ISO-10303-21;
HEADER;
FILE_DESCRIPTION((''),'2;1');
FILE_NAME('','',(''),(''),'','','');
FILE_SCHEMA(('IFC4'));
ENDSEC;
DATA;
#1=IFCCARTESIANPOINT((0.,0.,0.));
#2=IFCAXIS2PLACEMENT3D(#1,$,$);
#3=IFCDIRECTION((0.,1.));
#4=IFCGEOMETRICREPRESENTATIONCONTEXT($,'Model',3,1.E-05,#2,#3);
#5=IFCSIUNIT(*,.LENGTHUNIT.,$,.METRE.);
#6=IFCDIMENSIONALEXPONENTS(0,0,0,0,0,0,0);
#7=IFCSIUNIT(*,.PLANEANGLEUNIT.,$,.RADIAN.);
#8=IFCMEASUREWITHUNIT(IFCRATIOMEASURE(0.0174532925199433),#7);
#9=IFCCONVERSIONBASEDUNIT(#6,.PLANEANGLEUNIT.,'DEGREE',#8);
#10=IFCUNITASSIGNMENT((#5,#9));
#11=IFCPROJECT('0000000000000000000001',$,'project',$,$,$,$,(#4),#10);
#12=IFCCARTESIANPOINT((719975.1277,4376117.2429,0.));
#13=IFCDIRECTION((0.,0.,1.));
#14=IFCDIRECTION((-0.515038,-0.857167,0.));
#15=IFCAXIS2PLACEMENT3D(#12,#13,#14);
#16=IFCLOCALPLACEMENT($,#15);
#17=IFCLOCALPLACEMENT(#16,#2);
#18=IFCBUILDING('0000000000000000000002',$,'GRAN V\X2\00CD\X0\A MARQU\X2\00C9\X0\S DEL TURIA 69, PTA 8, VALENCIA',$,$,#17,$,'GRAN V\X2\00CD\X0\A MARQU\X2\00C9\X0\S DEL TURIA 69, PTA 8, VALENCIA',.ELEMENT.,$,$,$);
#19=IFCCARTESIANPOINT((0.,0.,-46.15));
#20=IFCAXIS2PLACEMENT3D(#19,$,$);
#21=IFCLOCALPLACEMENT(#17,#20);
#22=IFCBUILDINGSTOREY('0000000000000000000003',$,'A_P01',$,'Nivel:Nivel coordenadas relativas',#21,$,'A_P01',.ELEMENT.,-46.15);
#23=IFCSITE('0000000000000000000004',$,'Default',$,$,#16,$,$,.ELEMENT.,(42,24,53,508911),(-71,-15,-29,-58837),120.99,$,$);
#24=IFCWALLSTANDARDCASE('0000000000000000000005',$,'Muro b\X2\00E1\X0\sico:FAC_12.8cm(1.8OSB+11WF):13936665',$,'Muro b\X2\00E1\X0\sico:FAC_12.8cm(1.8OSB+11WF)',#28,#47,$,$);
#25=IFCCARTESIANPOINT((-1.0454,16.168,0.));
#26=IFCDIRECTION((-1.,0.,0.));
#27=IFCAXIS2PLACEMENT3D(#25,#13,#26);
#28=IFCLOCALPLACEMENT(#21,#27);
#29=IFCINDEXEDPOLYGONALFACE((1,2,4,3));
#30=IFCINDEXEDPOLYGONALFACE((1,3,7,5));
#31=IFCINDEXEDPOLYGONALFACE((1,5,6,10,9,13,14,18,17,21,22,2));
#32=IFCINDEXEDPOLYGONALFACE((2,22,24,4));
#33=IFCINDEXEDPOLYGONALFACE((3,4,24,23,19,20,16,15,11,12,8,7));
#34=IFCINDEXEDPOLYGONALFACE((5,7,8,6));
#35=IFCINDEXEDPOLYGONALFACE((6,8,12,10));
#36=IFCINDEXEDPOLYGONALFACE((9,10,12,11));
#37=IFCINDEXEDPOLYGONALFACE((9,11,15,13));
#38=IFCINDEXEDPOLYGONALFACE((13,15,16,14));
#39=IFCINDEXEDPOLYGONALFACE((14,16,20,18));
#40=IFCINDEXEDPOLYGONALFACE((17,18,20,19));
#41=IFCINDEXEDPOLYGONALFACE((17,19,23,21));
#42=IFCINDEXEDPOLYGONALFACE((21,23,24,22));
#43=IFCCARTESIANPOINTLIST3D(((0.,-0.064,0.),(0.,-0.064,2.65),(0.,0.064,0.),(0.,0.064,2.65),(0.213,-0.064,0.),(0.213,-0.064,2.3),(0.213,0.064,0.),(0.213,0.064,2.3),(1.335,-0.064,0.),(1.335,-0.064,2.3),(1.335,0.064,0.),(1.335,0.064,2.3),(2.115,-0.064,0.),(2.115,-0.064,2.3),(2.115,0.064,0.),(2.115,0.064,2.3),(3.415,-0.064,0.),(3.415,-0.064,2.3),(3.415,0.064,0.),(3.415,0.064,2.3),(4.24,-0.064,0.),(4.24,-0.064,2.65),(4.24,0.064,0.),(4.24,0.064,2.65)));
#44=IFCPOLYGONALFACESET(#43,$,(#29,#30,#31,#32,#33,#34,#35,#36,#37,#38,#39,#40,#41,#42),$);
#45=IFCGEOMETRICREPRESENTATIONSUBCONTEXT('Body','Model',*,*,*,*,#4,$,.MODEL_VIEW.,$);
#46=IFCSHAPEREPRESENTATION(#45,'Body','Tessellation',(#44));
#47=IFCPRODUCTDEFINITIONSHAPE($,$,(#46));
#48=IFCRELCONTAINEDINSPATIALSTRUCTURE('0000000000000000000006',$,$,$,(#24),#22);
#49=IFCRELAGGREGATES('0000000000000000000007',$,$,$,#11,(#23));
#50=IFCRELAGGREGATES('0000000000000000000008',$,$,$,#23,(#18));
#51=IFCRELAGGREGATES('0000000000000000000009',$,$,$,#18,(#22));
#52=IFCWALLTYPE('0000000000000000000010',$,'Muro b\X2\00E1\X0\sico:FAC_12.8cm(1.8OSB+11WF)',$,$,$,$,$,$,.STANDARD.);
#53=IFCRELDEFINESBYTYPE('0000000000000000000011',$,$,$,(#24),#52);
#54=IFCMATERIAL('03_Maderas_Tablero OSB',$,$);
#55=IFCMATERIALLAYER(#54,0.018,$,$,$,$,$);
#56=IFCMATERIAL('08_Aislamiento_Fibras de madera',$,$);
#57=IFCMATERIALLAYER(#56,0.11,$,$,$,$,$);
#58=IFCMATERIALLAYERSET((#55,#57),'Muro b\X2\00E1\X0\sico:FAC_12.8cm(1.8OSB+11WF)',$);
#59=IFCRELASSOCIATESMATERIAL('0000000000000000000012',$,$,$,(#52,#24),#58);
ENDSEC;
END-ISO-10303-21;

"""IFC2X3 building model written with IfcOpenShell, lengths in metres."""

from ifc_helpers import new_model, entity, si_unit, converted_unit, direction, frame, frame_2d, origin, place, context, subcontext, project, spatial, rectangle, extrude, material, layer, layer_set, layer_usage, type_object, element, save


model = new_model("IFC2X3")

# Units and contexts
model_context = context("Model", 3, precision=1e-05, world=origin(), true_north=direction((0.0, 1.0)))
body_context = subcontext(model_context, "Body", "Model", "MODEL_VIEW")
ifc_project = project(units=[si_unit("LENGTHUNIT", "METRE"), converted_unit("PLANEANGLEUNIT", "DEGREE", entity("IfcRatioMeasure", 0.0174532925199433), si_unit("PLANEANGLEUNIT", "RADIAN"), dimensions=[0, 0, 0, 0, 0, 0, 0])], contexts=[model_context])

# Site, building, storey
site_placement = place(None, frame((719975.1277, 4376117.2429, 0.0), z_axis=(0.0, 0.0, 1.0), x_axis=(-0.515038, -0.857167, 0.0)))
site = spatial("IfcSite", under=ifc_project, at=site_placement, Name="Default", CompositionType="ELEMENT", RefLatitude=(42, 24, 53, 508911), RefLongitude=(-71, -15, -29, -58837), RefElevation=120.99)
building_placement = place(site_placement, origin())
building = spatial("IfcBuilding", under=site, at=building_placement, Name="GRAN VÍA MARQUÉS DEL TURIA 69, PTA 8, VALENCIA", LongName="GRAN VÍA MARQUÉS DEL TURIA 69, PTA 8, VALENCIA", CompositionType="ELEMENT")
storey_placement = place(building_placement, frame((0.0, 0.0, -46.15)))
storey = spatial("IfcBuildingStorey", under=building, at=storey_placement, Name="A_P01", ObjectType="Nivel:Nivel coordenadas relativas", LongName="A_P01", CompositionType="ELEMENT", Elevation=-46.15)

# Shared definitions
ifc_material_1 = material(Name="03_Maderas_Tablero OSB")
ifc_layer_1 = layer(ifc_material_1, 0.018)
ifc_material_2 = material(Name="08_Aislamiento_Fibras de madera")
ifc_layer_2 = layer(ifc_material_2, 0.11)
ifc_layer_set_1 = layer_set([ifc_layer_1, ifc_layer_2], Name="Muro básico:FAC_12.8cm(1.8OSB+11WF)")
wall_type_1 = type_object("IfcWallType", Name="Muro básico:FAC_12.8cm(1.8OSB+11WF)", PredefinedType="STANDARD", material=ifc_layer_set_1)

# Wall, openings
ifc_layer_usage_1 = layer_usage(ifc_layer_set_1, "AXIS2", "NEGATIVE", 0.064)
wall_1_placement = place(storey_placement, frame((-1.0454, 16.168, 0.0), z_axis=(0.0, 0.0, 1.0), x_axis=(-1.0, 0.0, 0.0)))
wall_1 = element("IfcWallStandardCase", 1, at=wall_1_placement, inside=storey, type_object=wall_type_1, material=ifc_layer_usage_1, Name="Muro básico:FAC_12.8cm(1.8OSB+11WF):13936665", ObjectType="Muro básico:FAC_12.8cm(1.8OSB+11WF)", context=body_context, shape_type="SweptSolid", body=[
    extrude(rectangle(XDim=4.24, YDim=0.128, at=frame_2d((2.12, 0.0), x_axis=(-1.0, 0.0))), origin(), (0.0, 0.0, 1.0), 2.65),
])
opening_1_placement = place(wall_1_placement, origin())
element("IfcOpeningElement", 2, at=opening_1_placement, cuts=wall_1, ObjectType="Opening", context=body_context, shape_type="SweptSolid", body=[
    extrude(rectangle(XDim=2.3, YDim=1.122, at=frame_2d((0.0, 0.0), x_axis=(0.0, 1.0))), frame((0.774, -0.2164, 1.15), z_axis=(0.0, 1.0, 0.0), x_axis=(-1.0, 0.0, 0.0)), (0.0, 0.0, 1.0), 0.4328),
])
opening_2_placement = place(wall_1_placement, origin())
element("IfcOpeningElement", 3, at=opening_2_placement, cuts=wall_1, ObjectType="Opening", context=body_context, shape_type="SweptSolid", body=[
    extrude(rectangle(XDim=2.3, YDim=1.3, at=frame_2d((0.0, 0.0), x_axis=(0.0, 1.0))), frame((2.765, -0.2164, 1.15), z_axis=(0.0, 1.0, 0.0), x_axis=(-1.0, 0.0, 0.0)), (0.0, 0.0, 1.0), 0.4328),
])

save(model, "model.ifc")
